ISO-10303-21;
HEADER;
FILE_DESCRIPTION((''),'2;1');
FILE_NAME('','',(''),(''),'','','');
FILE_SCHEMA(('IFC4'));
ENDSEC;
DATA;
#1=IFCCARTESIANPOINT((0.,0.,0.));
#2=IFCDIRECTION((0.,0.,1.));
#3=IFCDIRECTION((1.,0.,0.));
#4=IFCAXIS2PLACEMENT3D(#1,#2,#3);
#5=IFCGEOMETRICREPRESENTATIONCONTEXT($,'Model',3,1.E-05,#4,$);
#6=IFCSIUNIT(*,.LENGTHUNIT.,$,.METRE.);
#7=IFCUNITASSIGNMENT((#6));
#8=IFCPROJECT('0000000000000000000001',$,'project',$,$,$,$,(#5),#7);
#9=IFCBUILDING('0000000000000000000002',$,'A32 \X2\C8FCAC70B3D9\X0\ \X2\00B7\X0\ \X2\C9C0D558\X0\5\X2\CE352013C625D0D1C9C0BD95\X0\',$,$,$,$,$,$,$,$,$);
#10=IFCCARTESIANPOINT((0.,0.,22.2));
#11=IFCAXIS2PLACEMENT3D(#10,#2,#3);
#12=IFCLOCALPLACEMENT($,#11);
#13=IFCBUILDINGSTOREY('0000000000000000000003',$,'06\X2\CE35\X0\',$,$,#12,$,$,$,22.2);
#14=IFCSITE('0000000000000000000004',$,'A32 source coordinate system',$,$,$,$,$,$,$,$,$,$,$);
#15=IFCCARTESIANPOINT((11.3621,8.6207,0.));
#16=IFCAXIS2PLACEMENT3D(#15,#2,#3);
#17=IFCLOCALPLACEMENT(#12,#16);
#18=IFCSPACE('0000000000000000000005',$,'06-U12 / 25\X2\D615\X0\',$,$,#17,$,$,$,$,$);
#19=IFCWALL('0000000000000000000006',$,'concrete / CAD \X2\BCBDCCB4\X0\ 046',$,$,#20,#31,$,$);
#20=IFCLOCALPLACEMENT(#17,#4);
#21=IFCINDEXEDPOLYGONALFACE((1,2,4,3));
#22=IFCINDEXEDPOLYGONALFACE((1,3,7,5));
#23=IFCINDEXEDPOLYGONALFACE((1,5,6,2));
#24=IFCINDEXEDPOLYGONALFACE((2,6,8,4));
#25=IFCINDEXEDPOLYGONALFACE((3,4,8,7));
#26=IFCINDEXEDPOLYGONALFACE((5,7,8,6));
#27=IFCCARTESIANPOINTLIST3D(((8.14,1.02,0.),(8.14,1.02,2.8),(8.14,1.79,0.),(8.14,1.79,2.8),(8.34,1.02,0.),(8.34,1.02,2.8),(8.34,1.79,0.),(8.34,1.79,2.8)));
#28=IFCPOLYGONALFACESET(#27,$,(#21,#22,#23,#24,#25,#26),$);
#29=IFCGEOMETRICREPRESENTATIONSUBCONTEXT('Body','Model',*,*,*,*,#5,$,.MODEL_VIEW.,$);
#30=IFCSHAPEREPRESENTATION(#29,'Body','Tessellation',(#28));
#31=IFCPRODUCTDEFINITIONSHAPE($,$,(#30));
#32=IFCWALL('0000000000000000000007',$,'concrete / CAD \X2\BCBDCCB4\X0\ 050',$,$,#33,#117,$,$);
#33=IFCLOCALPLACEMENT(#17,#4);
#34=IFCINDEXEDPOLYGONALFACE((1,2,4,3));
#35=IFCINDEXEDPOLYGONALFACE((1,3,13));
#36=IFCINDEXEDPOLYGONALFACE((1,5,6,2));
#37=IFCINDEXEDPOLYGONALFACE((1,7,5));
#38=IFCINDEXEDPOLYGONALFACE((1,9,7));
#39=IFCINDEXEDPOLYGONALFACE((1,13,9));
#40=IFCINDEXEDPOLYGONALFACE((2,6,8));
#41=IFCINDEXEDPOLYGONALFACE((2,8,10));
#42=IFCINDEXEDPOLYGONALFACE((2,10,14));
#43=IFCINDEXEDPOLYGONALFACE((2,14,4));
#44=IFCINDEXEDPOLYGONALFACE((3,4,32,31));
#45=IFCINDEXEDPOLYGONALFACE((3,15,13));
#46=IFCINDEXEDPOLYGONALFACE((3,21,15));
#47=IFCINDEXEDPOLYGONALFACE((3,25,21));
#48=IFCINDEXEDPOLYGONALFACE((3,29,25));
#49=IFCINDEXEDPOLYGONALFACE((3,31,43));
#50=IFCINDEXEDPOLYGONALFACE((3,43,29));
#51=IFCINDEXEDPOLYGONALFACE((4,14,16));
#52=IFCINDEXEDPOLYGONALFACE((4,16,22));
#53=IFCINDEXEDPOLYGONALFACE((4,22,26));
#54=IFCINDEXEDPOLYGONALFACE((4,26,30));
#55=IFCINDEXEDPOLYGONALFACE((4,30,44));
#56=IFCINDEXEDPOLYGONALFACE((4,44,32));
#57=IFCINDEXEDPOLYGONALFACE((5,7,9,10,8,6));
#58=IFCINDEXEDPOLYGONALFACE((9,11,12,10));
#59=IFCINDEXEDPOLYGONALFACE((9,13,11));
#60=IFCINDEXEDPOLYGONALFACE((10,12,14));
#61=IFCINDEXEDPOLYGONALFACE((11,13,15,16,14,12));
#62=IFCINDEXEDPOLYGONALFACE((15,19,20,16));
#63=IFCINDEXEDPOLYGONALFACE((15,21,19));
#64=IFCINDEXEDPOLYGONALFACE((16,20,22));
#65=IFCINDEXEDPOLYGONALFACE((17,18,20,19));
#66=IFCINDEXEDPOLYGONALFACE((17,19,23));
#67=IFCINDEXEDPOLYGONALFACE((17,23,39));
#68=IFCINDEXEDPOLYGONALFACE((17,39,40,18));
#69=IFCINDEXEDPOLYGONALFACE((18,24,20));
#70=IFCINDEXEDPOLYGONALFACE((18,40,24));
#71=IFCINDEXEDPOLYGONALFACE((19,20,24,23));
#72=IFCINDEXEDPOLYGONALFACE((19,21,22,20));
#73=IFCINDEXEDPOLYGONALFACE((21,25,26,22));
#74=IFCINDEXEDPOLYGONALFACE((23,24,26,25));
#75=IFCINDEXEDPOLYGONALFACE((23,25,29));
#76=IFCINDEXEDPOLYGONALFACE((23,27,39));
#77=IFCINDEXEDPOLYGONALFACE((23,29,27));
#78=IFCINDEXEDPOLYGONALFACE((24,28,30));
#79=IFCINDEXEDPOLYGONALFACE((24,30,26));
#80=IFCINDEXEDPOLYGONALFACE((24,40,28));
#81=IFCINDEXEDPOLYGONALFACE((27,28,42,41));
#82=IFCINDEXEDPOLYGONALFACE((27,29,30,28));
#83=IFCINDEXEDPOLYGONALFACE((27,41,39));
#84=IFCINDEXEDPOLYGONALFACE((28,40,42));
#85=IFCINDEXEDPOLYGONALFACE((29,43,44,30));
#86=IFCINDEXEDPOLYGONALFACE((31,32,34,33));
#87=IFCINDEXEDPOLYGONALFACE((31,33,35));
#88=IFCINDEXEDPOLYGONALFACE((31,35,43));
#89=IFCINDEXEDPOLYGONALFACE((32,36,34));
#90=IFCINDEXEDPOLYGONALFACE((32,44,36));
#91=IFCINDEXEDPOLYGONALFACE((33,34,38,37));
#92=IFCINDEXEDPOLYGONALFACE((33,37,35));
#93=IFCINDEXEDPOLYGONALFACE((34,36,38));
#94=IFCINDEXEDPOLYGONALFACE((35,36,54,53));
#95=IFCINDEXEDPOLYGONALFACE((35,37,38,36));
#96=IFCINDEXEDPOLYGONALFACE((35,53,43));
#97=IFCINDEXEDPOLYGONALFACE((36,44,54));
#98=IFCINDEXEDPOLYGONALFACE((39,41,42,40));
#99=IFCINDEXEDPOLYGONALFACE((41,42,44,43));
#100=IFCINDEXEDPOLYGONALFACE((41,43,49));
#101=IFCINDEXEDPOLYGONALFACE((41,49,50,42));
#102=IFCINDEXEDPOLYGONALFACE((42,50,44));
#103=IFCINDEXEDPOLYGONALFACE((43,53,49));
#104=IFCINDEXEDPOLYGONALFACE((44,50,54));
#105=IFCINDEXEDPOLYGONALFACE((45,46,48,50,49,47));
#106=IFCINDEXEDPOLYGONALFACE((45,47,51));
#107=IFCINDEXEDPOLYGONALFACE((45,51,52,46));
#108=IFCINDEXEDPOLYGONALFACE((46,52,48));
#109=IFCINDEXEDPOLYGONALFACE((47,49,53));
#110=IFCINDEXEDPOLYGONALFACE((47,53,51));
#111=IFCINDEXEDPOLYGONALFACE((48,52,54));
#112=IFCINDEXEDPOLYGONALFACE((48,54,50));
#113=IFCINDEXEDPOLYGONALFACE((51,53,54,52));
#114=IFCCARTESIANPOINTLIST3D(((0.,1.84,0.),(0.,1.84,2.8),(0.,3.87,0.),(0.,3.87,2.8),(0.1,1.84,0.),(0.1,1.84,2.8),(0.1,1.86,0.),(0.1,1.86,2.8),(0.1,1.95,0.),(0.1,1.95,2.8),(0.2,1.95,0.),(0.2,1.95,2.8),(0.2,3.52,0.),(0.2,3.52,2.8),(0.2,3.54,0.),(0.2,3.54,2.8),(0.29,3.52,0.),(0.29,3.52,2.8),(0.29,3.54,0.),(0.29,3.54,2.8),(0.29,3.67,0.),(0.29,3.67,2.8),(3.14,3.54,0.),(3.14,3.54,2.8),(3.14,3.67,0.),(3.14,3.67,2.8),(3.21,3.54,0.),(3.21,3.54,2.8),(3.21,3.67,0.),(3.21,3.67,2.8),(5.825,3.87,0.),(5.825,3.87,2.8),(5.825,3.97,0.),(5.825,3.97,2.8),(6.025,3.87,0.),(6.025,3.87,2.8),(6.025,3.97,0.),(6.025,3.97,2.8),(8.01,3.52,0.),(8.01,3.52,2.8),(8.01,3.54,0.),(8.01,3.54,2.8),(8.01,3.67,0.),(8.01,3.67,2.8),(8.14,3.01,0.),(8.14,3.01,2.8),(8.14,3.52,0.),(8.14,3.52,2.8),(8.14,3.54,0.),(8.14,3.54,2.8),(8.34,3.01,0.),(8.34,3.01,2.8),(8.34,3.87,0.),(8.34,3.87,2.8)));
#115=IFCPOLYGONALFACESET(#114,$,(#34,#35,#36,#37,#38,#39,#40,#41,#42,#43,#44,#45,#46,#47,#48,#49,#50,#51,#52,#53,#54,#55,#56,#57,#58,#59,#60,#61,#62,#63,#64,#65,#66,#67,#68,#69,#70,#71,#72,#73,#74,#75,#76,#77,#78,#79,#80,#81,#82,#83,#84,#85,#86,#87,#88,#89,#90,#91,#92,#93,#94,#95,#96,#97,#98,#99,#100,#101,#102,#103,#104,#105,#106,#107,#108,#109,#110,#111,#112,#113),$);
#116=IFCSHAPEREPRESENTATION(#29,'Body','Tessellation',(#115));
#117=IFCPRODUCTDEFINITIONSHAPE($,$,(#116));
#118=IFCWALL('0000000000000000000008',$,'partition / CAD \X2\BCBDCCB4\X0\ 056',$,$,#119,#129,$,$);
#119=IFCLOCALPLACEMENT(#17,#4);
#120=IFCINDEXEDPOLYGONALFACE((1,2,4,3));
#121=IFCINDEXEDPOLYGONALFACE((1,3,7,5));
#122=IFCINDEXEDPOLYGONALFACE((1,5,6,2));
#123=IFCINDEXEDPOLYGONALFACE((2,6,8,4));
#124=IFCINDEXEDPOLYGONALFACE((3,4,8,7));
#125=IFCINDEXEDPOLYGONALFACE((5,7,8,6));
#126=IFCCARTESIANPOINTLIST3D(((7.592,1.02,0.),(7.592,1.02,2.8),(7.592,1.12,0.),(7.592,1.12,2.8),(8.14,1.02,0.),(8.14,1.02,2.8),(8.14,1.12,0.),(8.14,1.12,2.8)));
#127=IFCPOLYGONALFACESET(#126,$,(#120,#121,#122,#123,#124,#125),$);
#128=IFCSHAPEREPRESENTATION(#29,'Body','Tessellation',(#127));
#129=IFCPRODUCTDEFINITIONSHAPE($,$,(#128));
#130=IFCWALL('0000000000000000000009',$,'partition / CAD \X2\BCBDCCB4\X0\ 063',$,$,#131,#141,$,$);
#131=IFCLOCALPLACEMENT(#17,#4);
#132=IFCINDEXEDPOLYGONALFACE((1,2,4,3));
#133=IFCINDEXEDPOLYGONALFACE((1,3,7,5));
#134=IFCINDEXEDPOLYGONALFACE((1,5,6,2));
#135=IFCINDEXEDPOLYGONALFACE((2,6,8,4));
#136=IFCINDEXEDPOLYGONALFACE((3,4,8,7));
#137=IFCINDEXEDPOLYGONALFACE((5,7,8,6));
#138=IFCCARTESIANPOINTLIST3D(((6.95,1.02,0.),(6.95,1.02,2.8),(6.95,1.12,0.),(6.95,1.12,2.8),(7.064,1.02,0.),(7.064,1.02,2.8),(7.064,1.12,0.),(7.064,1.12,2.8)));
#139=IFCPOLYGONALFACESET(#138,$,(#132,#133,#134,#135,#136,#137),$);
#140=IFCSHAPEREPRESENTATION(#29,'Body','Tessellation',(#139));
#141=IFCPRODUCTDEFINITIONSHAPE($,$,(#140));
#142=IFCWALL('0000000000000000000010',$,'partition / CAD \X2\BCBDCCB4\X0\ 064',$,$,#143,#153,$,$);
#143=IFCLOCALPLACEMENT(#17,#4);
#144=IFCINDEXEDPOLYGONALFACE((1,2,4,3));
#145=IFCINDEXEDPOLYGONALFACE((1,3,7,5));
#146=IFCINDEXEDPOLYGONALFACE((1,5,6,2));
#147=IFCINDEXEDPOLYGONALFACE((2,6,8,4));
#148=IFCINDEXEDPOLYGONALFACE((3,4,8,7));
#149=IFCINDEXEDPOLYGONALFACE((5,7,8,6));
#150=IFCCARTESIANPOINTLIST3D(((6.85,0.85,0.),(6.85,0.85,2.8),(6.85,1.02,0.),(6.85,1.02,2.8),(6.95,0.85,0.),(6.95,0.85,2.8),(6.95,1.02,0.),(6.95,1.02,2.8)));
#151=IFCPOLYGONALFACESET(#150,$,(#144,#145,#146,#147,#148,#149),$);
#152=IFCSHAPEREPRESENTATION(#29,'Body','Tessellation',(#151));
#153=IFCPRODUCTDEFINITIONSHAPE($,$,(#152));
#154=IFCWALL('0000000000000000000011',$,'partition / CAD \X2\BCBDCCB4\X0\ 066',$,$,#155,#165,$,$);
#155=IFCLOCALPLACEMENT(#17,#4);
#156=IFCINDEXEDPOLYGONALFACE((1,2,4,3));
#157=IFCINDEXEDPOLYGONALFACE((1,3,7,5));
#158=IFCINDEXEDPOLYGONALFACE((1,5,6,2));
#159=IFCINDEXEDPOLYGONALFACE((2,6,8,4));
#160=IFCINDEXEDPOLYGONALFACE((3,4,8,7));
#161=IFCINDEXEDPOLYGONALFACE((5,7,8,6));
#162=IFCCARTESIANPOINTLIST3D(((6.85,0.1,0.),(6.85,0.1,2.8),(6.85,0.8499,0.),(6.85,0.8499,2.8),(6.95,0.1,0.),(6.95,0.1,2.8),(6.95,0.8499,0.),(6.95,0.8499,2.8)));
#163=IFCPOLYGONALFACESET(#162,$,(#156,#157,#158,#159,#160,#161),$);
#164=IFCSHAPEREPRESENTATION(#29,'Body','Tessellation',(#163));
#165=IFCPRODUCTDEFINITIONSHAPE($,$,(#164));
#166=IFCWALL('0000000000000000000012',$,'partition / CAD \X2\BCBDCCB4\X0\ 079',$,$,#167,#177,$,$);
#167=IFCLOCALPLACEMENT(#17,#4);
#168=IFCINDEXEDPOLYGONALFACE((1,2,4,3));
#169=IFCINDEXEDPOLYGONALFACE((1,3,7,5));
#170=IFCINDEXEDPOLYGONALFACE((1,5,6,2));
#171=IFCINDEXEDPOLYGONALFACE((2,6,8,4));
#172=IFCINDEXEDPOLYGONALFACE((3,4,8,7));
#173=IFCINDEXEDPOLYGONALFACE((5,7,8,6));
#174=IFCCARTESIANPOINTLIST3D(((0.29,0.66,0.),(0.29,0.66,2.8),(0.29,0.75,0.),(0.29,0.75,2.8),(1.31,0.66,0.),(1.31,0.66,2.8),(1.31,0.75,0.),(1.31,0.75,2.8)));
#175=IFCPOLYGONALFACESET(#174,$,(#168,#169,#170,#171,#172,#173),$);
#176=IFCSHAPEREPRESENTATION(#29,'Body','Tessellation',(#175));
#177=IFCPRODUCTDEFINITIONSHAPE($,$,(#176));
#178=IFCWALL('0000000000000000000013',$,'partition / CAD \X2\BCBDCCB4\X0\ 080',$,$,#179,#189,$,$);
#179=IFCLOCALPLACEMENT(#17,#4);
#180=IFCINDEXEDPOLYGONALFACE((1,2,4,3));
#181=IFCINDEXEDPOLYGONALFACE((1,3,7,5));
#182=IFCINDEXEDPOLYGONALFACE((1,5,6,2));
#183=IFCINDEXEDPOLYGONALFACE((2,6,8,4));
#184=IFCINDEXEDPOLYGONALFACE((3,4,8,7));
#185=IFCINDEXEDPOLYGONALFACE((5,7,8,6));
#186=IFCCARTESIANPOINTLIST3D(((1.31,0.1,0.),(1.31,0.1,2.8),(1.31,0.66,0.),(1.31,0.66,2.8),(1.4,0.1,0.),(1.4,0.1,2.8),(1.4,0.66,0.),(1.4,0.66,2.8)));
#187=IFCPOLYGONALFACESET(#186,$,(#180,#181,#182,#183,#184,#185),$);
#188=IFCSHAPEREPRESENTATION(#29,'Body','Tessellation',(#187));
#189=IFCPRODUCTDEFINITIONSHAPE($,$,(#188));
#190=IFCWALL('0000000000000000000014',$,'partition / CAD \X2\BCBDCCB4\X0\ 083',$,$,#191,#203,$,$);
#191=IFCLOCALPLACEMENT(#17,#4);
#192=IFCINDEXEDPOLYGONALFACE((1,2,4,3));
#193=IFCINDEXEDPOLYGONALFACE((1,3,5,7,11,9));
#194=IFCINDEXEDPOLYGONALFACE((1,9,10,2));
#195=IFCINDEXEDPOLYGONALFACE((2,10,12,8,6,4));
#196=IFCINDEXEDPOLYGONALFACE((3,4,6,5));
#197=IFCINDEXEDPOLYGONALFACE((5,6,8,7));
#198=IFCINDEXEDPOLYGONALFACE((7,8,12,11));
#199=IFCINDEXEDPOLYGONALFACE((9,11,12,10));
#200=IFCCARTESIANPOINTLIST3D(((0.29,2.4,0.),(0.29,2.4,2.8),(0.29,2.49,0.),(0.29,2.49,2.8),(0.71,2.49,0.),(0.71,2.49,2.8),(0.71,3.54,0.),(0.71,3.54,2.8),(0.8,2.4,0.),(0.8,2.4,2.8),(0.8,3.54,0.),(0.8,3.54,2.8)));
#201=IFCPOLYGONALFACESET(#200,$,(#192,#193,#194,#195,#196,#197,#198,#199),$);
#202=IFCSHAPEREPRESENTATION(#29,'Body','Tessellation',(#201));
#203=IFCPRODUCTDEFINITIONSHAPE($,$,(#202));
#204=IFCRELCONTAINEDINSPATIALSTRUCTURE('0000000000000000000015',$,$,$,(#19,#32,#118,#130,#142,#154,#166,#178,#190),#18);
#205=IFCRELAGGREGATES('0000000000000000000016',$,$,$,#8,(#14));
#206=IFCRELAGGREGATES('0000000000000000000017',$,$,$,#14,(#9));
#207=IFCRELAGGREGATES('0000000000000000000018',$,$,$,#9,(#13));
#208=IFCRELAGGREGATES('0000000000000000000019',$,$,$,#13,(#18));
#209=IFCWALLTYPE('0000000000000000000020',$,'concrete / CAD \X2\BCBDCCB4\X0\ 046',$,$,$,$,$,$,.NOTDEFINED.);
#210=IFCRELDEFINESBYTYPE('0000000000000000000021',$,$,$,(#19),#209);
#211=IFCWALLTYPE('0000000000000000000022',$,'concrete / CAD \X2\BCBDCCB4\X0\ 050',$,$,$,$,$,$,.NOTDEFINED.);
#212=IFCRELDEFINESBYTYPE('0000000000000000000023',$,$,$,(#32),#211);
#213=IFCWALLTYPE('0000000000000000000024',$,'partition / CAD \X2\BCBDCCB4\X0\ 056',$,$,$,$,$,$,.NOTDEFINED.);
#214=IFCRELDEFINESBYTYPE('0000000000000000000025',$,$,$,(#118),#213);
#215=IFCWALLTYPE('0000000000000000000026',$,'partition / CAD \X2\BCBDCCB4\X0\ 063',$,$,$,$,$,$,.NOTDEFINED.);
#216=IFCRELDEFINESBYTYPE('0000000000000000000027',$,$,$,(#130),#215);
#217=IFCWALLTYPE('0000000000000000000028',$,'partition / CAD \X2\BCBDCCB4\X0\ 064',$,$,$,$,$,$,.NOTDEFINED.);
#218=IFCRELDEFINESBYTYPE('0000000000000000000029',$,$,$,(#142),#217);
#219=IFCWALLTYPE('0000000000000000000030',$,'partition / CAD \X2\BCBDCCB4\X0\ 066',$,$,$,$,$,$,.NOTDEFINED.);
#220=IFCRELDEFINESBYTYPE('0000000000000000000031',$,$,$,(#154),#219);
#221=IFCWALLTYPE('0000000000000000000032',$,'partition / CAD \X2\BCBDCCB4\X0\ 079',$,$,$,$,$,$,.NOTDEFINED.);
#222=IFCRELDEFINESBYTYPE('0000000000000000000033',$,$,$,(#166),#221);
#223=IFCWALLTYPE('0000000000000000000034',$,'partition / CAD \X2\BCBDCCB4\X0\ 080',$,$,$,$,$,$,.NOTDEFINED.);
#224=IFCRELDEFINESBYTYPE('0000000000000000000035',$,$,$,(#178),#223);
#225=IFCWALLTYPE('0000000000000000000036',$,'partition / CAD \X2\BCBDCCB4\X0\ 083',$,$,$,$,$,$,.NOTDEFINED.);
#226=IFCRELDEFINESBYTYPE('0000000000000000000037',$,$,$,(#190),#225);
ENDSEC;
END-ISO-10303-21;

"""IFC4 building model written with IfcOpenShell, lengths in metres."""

from ifc_helpers import new_model, si_unit, frame, origin, origin_with_axes, place, context, subcontext, project, spatial, polyline, outline, extrude, source, transform, mapped, type_object, type_shapes, element, save


model = new_model("IFC4")

# Units and contexts
model_context = context("Model", 3, precision=1e-05, world=origin_with_axes())
body_context = subcontext(model_context, "Body", "Model", "MODEL_VIEW")
ifc_project = project(units=[si_unit("LENGTHUNIT", "METRE")], contexts=[model_context])

# Site, building, storey, space
site = spatial("IfcSite", under=ifc_project, Name="A32 source coordinate system")
building = spatial("IfcBuilding", under=site, Name="A32 주거동 · 지하5층–옥탑지붕")
storey_placement = place(None, frame((0.0, 0.0, 22.2), z_axis=(0.0, 0.0, 1.0), x_axis=(1.0, 0.0, 0.0)))
storey = spatial("IfcBuildingStorey", under=building, at=storey_placement, Name="06층", Elevation=22.2)
space_1_placement = place(storey_placement, frame((11.3621, 8.6207, 0.0), z_axis=(0.0, 0.0, 1.0), x_axis=(1.0, 0.0, 0.0)))
space_1 = spatial("IfcSpace", under=storey, at=space_1_placement, Name="06-U12 / 25형")

# Walls
wall_type_1 = type_object("IfcWallType", Name="concrete / CAD 벽체 046", PredefinedType="NOTDEFINED")
shared_shape_1 = source(origin(), body_context, "Body", "SweptSolid", [
    extrude(outline(polyline([(8.14, 1.02), (8.14, 1.79), (8.34, 1.79), (8.34, 1.02), (8.14, 1.02)])), origin(), (0.0, 0.0, 1.0), 2.8),
])
type_shapes(wall_type_1, [shared_shape_1])
wall_1_placement = place(space_1_placement, origin_with_axes())
element("IfcWall", 1, at=wall_1_placement, inside=space_1, type_object=wall_type_1, Name="concrete / CAD 벽체 046", context=body_context, shape_type="MappedRepresentation", body=[
    mapped(shared_shape_1, transform((0.0, 0.0, 0.0), scale=1.0)),
])
wall_type_2 = type_object("IfcWallType", Name="concrete / CAD 벽체 050", PredefinedType="NOTDEFINED")
shared_shape_2 = source(origin(), body_context, "Body", "SweptSolid", [
    extrude(outline(polyline([(8.01, 3.52), (0.29, 3.52), (0.29, 3.54), (0.2, 3.54), (0.2, 3.52), (0.2, 1.95), (0.1, 1.95), (0.1, 1.86), (0.1, 1.84), (0.0, 1.84), (0.0, 3.87), (5.825, 3.87), (5.825, 3.97), (6.025, 3.97), (6.025, 3.87), (8.34, 3.87), (8.34, 3.01), (8.14, 3.01), (8.14, 3.52), (8.14, 3.54), (8.01, 3.54), (8.01, 3.52)]), holes=[polyline([(3.14, 3.54), (3.14, 3.67), (0.29, 3.67), (0.29, 3.54), (3.14, 3.54)]), polyline([(8.01, 3.67), (3.21, 3.67), (3.21, 3.54), (8.01, 3.54), (8.01, 3.67)])]), origin(), (0.0, 0.0, 1.0), 2.8),
])
type_shapes(wall_type_2, [shared_shape_2])
wall_2_placement = place(space_1_placement, origin_with_axes())
element("IfcWall", 2, at=wall_2_placement, inside=space_1, type_object=wall_type_2, Name="concrete / CAD 벽체 050", context=body_context, shape_type="MappedRepresentation", body=[
    mapped(shared_shape_2, transform((0.0, 0.0, 0.0), scale=1.0)),
])
wall_type_3 = type_object("IfcWallType", Name="partition / CAD 벽체 056", PredefinedType="NOTDEFINED")
shared_shape_3 = source(origin(), body_context, "Body", "SweptSolid", [
    extrude(outline(polyline([(7.592, 1.12), (8.14, 1.12), (8.14, 1.02), (7.592, 1.02), (7.592, 1.12)])), origin(), (0.0, 0.0, 1.0), 2.8),
])
type_shapes(wall_type_3, [shared_shape_3])
wall_3_placement = place(space_1_placement, origin_with_axes())
element("IfcWall", 3, at=wall_3_placement, inside=space_1, type_object=wall_type_3, Name="partition / CAD 벽체 056", context=body_context, shape_type="MappedRepresentation", body=[
    mapped(shared_shape_3, transform((0.0, 0.0, 0.0), scale=1.0)),
])
wall_type_4 = type_object("IfcWallType", Name="partition / CAD 벽체 063", PredefinedType="NOTDEFINED")
shared_shape_4 = source(origin(), body_context, "Body", "SweptSolid", [
    extrude(outline(polyline([(6.95, 1.12), (7.064, 1.12), (7.064, 1.02), (6.95, 1.02), (6.95, 1.12)])), origin(), (0.0, 0.0, 1.0), 2.8),
])
type_shapes(wall_type_4, [shared_shape_4])
wall_4_placement = place(space_1_placement, origin_with_axes())
element("IfcWall", 4, at=wall_4_placement, inside=space_1, type_object=wall_type_4, Name="partition / CAD 벽체 063", context=body_context, shape_type="MappedRepresentation", body=[
    mapped(shared_shape_4, transform((0.0, 0.0, 0.0), scale=1.0)),
])
wall_type_5 = type_object("IfcWallType", Name="partition / CAD 벽체 064", PredefinedType="NOTDEFINED")
shared_shape_5 = source(origin(), body_context, "Body", "SweptSolid", [
    extrude(outline(polyline([(6.95, 0.85), (6.85, 0.85), (6.85, 1.02), (6.95, 1.02), (6.95, 0.85)])), origin(), (0.0, 0.0, 1.0), 2.8),
])
type_shapes(wall_type_5, [shared_shape_5])
wall_5_placement = place(space_1_placement, origin_with_axes())
element("IfcWall", 5, at=wall_5_placement, inside=space_1, type_object=wall_type_5, Name="partition / CAD 벽체 064", context=body_context, shape_type="MappedRepresentation", body=[
    mapped(shared_shape_5, transform((0.0, 0.0, 0.0), scale=1.0)),
])
wall_type_6 = type_object("IfcWallType", Name="partition / CAD 벽체 066", PredefinedType="NOTDEFINED")
shared_shape_6 = source(origin(), body_context, "Body", "SweptSolid", [
    extrude(outline(polyline([(6.85, 0.8499), (6.95, 0.8499), (6.95, 0.1), (6.85, 0.1), (6.85, 0.8499)])), origin(), (0.0, 0.0, 1.0), 2.8),
])
type_shapes(wall_type_6, [shared_shape_6])
wall_6_placement = place(space_1_placement, origin_with_axes())
element("IfcWall", 6, at=wall_6_placement, inside=space_1, type_object=wall_type_6, Name="partition / CAD 벽체 066", context=body_context, shape_type="MappedRepresentation", body=[
    mapped(shared_shape_6, transform((0.0, 0.0, 0.0), scale=1.0)),
])
wall_type_7 = type_object("IfcWallType", Name="partition / CAD 벽체 079", PredefinedType="NOTDEFINED")
shared_shape_7 = source(origin(), body_context, "Body", "SweptSolid", [
    extrude(outline(polyline([(0.29, 0.75), (1.31, 0.75), (1.31, 0.66), (0.29, 0.66), (0.29, 0.75)])), origin(), (0.0, 0.0, 1.0), 2.8),
])
type_shapes(wall_type_7, [shared_shape_7])
wall_7_placement = place(space_1_placement, origin_with_axes())
element("IfcWall", 7, at=wall_7_placement, inside=space_1, type_object=wall_type_7, Name="partition / CAD 벽체 079", context=body_context, shape_type="MappedRepresentation", body=[
    mapped(shared_shape_7, transform((0.0, 0.0, 0.0), scale=1.0)),
])
wall_type_8 = type_object("IfcWallType", Name="partition / CAD 벽체 080", PredefinedType="NOTDEFINED")
shared_shape_8 = source(origin(), body_context, "Body", "SweptSolid", [
    extrude(outline(polyline([(1.4, 0.66), (1.4, 0.1), (1.31, 0.1), (1.31, 0.66), (1.4, 0.66)])), origin(), (0.0, 0.0, 1.0), 2.8),
])
type_shapes(wall_type_8, [shared_shape_8])
wall_8_placement = place(space_1_placement, origin_with_axes())
element("IfcWall", 8, at=wall_8_placement, inside=space_1, type_object=wall_type_8, Name="partition / CAD 벽체 080", context=body_context, shape_type="MappedRepresentation", body=[
    mapped(shared_shape_8, transform((0.0, 0.0, 0.0), scale=1.0)),
])
wall_type_9 = type_object("IfcWallType", Name="partition / CAD 벽체 083", PredefinedType="NOTDEFINED")
shared_shape_9 = source(origin(), body_context, "Body", "SweptSolid", [
    extrude(outline(polyline([(0.71, 2.49), (0.71, 3.54), (0.8, 3.54), (0.8, 2.4), (0.29, 2.4), (0.29, 2.49), (0.71, 2.49)])), origin(), (0.0, 0.0, 1.0), 2.8),
])
type_shapes(wall_type_9, [shared_shape_9])
wall_9_placement = place(space_1_placement, origin_with_axes())
element("IfcWall", 9, at=wall_9_placement, inside=space_1, type_object=wall_type_9, Name="partition / CAD 벽체 083", context=body_context, shape_type="MappedRepresentation", body=[
    mapped(shared_shape_9, transform((0.0, 0.0, 0.0), scale=1.0)),
])

save(model, "model.ifc")
